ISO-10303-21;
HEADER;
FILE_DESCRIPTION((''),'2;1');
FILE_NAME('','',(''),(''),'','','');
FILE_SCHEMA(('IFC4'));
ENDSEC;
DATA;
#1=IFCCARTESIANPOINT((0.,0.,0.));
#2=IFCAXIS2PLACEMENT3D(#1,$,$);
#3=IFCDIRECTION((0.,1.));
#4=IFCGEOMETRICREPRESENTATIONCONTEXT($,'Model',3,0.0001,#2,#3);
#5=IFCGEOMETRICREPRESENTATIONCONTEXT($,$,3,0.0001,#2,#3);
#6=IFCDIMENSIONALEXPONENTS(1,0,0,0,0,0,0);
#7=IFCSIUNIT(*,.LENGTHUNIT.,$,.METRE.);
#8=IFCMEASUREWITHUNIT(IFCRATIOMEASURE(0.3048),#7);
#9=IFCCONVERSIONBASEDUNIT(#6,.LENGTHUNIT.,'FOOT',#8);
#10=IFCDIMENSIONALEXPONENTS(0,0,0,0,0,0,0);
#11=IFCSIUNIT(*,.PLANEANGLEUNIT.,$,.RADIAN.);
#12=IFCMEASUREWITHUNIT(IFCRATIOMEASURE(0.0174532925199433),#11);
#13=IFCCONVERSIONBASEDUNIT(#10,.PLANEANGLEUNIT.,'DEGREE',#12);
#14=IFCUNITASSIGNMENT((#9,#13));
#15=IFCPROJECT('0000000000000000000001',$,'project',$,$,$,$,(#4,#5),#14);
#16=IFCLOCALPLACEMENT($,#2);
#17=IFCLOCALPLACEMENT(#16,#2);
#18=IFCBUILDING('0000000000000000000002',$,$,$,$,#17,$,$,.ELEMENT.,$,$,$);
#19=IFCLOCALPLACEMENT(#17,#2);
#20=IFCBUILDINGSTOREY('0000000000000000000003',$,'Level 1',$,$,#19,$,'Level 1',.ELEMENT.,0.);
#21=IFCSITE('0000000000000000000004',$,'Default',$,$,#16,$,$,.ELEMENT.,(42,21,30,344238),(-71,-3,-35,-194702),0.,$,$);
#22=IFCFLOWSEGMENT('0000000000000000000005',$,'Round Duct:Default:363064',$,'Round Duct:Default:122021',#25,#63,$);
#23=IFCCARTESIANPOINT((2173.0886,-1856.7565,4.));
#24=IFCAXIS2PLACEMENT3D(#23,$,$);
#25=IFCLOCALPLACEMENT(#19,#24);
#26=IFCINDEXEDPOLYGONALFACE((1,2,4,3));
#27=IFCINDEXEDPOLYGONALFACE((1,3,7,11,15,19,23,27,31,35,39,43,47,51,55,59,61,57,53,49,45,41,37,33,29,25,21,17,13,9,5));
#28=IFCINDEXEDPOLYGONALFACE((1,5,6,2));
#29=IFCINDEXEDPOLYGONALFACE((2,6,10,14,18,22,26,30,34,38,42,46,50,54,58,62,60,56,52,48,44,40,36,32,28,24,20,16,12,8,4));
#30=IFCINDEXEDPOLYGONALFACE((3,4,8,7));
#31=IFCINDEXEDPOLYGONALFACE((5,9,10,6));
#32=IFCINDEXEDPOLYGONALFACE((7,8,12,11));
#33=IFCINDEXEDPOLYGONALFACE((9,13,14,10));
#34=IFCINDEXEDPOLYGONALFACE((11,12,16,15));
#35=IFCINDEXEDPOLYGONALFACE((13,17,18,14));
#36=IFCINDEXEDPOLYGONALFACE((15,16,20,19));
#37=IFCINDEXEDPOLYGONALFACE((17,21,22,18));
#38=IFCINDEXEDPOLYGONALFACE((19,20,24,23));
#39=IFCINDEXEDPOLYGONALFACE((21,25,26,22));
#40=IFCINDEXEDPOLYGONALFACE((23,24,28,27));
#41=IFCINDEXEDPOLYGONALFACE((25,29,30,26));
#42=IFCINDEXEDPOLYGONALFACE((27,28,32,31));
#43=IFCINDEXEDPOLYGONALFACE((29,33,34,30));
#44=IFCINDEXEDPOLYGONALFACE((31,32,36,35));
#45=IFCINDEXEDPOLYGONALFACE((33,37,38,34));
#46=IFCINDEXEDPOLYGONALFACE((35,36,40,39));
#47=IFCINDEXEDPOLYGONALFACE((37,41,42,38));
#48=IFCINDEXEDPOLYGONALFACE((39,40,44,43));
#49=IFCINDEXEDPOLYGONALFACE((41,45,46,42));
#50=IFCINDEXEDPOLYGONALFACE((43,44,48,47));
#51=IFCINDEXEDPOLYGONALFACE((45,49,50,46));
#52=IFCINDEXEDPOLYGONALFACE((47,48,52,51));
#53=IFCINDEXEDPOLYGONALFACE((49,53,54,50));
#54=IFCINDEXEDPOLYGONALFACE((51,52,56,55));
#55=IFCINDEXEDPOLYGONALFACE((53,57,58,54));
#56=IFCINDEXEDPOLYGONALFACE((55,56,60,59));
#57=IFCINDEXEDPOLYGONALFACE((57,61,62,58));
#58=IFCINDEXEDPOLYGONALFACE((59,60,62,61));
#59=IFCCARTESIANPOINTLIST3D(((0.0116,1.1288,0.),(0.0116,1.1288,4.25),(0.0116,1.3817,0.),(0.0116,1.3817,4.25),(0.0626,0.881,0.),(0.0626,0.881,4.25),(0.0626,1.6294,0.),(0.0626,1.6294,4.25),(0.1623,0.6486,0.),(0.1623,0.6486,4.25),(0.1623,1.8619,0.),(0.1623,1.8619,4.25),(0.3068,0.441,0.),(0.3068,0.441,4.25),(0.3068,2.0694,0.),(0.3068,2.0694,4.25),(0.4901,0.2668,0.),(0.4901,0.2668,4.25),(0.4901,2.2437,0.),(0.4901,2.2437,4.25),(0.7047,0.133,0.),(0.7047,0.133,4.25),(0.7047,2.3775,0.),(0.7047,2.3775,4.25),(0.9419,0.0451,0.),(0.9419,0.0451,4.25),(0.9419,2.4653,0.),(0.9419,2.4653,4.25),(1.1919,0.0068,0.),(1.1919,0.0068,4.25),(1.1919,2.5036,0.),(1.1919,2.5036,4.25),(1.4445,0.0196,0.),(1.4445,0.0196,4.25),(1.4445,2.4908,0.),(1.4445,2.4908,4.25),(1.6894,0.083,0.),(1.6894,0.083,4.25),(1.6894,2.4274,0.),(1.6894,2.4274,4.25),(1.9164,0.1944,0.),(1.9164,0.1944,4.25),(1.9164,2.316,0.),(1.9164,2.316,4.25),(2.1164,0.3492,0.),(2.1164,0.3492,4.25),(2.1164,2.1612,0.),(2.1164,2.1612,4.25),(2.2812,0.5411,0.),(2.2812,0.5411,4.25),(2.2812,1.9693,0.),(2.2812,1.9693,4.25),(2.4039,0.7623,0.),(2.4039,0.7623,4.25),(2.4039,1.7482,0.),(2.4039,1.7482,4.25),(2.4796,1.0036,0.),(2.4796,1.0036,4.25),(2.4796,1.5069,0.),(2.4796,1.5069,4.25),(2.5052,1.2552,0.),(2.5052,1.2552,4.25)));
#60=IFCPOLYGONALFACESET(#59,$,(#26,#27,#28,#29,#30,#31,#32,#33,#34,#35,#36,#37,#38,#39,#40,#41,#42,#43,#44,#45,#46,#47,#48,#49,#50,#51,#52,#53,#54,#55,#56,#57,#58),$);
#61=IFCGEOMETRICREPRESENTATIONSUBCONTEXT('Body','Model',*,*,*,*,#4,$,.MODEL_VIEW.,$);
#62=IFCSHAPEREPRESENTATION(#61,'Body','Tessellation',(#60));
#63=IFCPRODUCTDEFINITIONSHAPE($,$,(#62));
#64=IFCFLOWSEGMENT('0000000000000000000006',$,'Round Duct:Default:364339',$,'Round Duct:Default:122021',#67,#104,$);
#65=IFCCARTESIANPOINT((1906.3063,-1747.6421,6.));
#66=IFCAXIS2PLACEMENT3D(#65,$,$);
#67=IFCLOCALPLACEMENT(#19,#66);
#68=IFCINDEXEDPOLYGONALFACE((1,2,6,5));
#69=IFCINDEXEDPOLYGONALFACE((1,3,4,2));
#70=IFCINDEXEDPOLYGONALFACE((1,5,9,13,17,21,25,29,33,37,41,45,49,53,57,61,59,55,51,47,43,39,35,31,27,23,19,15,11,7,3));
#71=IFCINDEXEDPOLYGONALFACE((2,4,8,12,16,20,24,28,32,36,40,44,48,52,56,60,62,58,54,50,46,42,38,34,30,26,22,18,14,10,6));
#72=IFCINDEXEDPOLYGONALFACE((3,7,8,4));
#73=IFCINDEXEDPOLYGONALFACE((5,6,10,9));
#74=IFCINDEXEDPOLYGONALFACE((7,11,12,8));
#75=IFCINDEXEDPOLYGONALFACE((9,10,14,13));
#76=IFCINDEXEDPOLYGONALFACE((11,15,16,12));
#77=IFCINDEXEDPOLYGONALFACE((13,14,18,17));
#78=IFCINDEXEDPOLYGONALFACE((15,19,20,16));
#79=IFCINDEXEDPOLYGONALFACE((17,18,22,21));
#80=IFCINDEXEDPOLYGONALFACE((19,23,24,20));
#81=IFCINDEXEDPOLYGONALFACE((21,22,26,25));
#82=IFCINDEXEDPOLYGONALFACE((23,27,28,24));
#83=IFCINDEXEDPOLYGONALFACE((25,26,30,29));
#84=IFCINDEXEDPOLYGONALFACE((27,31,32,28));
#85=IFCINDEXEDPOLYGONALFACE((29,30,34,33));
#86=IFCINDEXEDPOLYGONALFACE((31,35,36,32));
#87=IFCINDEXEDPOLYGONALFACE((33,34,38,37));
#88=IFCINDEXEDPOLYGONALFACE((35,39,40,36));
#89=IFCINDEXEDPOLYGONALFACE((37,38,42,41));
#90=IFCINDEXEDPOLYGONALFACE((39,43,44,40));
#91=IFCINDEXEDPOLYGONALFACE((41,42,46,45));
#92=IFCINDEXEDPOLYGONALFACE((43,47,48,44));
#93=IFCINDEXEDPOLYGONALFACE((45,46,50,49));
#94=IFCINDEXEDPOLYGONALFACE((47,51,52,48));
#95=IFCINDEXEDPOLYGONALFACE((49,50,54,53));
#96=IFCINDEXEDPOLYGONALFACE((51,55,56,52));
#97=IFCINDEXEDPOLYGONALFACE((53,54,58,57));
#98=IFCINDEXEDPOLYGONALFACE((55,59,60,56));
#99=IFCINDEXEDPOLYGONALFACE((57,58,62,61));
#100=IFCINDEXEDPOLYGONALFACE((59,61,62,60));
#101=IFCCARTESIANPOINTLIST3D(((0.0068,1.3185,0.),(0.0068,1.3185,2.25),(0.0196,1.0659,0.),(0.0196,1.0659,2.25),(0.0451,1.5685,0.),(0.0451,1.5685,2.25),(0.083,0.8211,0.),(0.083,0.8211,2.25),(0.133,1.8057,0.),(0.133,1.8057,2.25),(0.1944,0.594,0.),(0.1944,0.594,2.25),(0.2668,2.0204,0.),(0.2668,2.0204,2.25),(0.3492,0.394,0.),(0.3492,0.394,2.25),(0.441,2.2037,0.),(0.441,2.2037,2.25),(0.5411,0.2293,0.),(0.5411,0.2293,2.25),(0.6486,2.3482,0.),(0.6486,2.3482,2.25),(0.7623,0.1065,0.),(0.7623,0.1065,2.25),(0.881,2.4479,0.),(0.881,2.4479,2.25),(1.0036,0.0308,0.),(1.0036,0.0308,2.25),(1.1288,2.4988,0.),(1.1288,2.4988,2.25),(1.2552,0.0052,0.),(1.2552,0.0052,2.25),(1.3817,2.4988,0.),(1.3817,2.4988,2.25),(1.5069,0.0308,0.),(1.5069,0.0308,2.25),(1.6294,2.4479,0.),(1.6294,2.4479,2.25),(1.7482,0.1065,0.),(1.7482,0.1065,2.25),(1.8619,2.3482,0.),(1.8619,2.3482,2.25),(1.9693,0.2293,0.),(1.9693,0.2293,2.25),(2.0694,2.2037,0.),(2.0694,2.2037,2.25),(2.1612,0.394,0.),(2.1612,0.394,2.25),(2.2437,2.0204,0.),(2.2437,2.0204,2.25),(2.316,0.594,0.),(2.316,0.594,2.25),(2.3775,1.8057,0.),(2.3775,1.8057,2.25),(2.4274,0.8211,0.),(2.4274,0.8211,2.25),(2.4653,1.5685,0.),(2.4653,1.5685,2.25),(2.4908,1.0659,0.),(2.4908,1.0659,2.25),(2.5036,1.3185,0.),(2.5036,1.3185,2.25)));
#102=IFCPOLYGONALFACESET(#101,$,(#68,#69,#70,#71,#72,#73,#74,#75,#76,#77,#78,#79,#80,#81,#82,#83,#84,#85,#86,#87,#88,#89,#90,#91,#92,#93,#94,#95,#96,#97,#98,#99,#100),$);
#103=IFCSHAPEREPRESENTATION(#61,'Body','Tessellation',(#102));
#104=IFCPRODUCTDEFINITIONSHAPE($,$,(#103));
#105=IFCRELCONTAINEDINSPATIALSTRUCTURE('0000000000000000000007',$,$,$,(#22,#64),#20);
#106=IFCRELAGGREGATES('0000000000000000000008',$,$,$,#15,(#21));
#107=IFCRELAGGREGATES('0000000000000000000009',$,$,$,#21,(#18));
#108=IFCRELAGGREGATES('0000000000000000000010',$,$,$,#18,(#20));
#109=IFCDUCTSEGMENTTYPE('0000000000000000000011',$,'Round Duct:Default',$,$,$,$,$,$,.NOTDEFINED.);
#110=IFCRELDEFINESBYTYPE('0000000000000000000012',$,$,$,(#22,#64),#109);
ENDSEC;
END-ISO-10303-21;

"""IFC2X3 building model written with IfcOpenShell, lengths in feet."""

from ifc_helpers import new_model, entity, si_unit, converted_unit, direction, frame, origin, origin_2d_with_axis, place, context, subcontext, project, spatial, circle, extrude, type_object, element, save


model = new_model("IFC2X3")

# Units and contexts
model_context = context("Model", 3, precision=0.0001, world=origin(), true_north=direction((0.0, 1.0)))
context_of_model = context(None, 3, precision=0.0001, world=origin(), true_north=direction((0.0, 1.0)))
body_context = subcontext(model_context, "Body", "Model", "MODEL_VIEW")
ifc_project = project(units=[converted_unit("LENGTHUNIT", "FOOT", entity("IfcRatioMeasure", 0.3048), si_unit("LENGTHUNIT", "METRE"), dimensions=[1, 0, 0, 0, 0, 0, 0]), converted_unit("PLANEANGLEUNIT", "DEGREE", entity("IfcRatioMeasure", 0.0174532925199433), si_unit("PLANEANGLEUNIT", "RADIAN"), dimensions=[0, 0, 0, 0, 0, 0, 0])], contexts=[model_context, context_of_model])

# Site, building, storey
site_placement = place(None, origin())
site = spatial("IfcSite", under=ifc_project, at=site_placement, Name="Default", CompositionType="ELEMENT", RefLatitude=(42, 21, 30, 344238), RefLongitude=(-71, -3, -35, -194702), RefElevation=0.0)
building_placement = place(site_placement, origin())
building = spatial("IfcBuilding", under=site, at=building_placement, CompositionType="ELEMENT")
storey_placement = place(building_placement, origin())
storey = spatial("IfcBuildingStorey", under=building, at=storey_placement, Name="Level 1", LongName="Level 1", CompositionType="ELEMENT", Elevation=0.0)

# Flow segments
duct_segment_type = type_object("IfcDuctSegmentType", Name="Round Duct:Default", PredefinedType="NOTDEFINED")
flow_segment_1_placement = place(storey_placement, frame((2173.0886, -1856.7565, 4.0)))
element("IfcFlowSegment", 1, at=flow_segment_1_placement, inside=storey, type_object=duct_segment_type, Name="Round Duct:Default:363064", ObjectType="Round Duct:Default:122021", context=body_context, shape_type="SweptSolid", body=[
    extrude(circle(Radius=1.25, at=origin_2d_with_axis()), frame((1.2552, 1.2552, 0.0)), (0.0, 0.0, 1.0), 4.25),
])
flow_segment_2_placement = place(storey_placement, frame((1906.3063, -1747.6421, 6.0)))
element("IfcFlowSegment", 2, at=flow_segment_2_placement, inside=storey, type_object=duct_segment_type, Name="Round Duct:Default:364339", ObjectType="Round Duct:Default:122021", context=body_context, shape_type="SweptSolid", body=[
    extrude(circle(Radius=1.25, at=origin_2d_with_axis()), frame((1.2552, 1.2552, 0.0), z_axis=(0.0, 0.0, 1.0), x_axis=(0.0, -1.0, 0.0)), (0.0, 0.0, 1.0), 2.25),
])

save(model, "model.ifc")
